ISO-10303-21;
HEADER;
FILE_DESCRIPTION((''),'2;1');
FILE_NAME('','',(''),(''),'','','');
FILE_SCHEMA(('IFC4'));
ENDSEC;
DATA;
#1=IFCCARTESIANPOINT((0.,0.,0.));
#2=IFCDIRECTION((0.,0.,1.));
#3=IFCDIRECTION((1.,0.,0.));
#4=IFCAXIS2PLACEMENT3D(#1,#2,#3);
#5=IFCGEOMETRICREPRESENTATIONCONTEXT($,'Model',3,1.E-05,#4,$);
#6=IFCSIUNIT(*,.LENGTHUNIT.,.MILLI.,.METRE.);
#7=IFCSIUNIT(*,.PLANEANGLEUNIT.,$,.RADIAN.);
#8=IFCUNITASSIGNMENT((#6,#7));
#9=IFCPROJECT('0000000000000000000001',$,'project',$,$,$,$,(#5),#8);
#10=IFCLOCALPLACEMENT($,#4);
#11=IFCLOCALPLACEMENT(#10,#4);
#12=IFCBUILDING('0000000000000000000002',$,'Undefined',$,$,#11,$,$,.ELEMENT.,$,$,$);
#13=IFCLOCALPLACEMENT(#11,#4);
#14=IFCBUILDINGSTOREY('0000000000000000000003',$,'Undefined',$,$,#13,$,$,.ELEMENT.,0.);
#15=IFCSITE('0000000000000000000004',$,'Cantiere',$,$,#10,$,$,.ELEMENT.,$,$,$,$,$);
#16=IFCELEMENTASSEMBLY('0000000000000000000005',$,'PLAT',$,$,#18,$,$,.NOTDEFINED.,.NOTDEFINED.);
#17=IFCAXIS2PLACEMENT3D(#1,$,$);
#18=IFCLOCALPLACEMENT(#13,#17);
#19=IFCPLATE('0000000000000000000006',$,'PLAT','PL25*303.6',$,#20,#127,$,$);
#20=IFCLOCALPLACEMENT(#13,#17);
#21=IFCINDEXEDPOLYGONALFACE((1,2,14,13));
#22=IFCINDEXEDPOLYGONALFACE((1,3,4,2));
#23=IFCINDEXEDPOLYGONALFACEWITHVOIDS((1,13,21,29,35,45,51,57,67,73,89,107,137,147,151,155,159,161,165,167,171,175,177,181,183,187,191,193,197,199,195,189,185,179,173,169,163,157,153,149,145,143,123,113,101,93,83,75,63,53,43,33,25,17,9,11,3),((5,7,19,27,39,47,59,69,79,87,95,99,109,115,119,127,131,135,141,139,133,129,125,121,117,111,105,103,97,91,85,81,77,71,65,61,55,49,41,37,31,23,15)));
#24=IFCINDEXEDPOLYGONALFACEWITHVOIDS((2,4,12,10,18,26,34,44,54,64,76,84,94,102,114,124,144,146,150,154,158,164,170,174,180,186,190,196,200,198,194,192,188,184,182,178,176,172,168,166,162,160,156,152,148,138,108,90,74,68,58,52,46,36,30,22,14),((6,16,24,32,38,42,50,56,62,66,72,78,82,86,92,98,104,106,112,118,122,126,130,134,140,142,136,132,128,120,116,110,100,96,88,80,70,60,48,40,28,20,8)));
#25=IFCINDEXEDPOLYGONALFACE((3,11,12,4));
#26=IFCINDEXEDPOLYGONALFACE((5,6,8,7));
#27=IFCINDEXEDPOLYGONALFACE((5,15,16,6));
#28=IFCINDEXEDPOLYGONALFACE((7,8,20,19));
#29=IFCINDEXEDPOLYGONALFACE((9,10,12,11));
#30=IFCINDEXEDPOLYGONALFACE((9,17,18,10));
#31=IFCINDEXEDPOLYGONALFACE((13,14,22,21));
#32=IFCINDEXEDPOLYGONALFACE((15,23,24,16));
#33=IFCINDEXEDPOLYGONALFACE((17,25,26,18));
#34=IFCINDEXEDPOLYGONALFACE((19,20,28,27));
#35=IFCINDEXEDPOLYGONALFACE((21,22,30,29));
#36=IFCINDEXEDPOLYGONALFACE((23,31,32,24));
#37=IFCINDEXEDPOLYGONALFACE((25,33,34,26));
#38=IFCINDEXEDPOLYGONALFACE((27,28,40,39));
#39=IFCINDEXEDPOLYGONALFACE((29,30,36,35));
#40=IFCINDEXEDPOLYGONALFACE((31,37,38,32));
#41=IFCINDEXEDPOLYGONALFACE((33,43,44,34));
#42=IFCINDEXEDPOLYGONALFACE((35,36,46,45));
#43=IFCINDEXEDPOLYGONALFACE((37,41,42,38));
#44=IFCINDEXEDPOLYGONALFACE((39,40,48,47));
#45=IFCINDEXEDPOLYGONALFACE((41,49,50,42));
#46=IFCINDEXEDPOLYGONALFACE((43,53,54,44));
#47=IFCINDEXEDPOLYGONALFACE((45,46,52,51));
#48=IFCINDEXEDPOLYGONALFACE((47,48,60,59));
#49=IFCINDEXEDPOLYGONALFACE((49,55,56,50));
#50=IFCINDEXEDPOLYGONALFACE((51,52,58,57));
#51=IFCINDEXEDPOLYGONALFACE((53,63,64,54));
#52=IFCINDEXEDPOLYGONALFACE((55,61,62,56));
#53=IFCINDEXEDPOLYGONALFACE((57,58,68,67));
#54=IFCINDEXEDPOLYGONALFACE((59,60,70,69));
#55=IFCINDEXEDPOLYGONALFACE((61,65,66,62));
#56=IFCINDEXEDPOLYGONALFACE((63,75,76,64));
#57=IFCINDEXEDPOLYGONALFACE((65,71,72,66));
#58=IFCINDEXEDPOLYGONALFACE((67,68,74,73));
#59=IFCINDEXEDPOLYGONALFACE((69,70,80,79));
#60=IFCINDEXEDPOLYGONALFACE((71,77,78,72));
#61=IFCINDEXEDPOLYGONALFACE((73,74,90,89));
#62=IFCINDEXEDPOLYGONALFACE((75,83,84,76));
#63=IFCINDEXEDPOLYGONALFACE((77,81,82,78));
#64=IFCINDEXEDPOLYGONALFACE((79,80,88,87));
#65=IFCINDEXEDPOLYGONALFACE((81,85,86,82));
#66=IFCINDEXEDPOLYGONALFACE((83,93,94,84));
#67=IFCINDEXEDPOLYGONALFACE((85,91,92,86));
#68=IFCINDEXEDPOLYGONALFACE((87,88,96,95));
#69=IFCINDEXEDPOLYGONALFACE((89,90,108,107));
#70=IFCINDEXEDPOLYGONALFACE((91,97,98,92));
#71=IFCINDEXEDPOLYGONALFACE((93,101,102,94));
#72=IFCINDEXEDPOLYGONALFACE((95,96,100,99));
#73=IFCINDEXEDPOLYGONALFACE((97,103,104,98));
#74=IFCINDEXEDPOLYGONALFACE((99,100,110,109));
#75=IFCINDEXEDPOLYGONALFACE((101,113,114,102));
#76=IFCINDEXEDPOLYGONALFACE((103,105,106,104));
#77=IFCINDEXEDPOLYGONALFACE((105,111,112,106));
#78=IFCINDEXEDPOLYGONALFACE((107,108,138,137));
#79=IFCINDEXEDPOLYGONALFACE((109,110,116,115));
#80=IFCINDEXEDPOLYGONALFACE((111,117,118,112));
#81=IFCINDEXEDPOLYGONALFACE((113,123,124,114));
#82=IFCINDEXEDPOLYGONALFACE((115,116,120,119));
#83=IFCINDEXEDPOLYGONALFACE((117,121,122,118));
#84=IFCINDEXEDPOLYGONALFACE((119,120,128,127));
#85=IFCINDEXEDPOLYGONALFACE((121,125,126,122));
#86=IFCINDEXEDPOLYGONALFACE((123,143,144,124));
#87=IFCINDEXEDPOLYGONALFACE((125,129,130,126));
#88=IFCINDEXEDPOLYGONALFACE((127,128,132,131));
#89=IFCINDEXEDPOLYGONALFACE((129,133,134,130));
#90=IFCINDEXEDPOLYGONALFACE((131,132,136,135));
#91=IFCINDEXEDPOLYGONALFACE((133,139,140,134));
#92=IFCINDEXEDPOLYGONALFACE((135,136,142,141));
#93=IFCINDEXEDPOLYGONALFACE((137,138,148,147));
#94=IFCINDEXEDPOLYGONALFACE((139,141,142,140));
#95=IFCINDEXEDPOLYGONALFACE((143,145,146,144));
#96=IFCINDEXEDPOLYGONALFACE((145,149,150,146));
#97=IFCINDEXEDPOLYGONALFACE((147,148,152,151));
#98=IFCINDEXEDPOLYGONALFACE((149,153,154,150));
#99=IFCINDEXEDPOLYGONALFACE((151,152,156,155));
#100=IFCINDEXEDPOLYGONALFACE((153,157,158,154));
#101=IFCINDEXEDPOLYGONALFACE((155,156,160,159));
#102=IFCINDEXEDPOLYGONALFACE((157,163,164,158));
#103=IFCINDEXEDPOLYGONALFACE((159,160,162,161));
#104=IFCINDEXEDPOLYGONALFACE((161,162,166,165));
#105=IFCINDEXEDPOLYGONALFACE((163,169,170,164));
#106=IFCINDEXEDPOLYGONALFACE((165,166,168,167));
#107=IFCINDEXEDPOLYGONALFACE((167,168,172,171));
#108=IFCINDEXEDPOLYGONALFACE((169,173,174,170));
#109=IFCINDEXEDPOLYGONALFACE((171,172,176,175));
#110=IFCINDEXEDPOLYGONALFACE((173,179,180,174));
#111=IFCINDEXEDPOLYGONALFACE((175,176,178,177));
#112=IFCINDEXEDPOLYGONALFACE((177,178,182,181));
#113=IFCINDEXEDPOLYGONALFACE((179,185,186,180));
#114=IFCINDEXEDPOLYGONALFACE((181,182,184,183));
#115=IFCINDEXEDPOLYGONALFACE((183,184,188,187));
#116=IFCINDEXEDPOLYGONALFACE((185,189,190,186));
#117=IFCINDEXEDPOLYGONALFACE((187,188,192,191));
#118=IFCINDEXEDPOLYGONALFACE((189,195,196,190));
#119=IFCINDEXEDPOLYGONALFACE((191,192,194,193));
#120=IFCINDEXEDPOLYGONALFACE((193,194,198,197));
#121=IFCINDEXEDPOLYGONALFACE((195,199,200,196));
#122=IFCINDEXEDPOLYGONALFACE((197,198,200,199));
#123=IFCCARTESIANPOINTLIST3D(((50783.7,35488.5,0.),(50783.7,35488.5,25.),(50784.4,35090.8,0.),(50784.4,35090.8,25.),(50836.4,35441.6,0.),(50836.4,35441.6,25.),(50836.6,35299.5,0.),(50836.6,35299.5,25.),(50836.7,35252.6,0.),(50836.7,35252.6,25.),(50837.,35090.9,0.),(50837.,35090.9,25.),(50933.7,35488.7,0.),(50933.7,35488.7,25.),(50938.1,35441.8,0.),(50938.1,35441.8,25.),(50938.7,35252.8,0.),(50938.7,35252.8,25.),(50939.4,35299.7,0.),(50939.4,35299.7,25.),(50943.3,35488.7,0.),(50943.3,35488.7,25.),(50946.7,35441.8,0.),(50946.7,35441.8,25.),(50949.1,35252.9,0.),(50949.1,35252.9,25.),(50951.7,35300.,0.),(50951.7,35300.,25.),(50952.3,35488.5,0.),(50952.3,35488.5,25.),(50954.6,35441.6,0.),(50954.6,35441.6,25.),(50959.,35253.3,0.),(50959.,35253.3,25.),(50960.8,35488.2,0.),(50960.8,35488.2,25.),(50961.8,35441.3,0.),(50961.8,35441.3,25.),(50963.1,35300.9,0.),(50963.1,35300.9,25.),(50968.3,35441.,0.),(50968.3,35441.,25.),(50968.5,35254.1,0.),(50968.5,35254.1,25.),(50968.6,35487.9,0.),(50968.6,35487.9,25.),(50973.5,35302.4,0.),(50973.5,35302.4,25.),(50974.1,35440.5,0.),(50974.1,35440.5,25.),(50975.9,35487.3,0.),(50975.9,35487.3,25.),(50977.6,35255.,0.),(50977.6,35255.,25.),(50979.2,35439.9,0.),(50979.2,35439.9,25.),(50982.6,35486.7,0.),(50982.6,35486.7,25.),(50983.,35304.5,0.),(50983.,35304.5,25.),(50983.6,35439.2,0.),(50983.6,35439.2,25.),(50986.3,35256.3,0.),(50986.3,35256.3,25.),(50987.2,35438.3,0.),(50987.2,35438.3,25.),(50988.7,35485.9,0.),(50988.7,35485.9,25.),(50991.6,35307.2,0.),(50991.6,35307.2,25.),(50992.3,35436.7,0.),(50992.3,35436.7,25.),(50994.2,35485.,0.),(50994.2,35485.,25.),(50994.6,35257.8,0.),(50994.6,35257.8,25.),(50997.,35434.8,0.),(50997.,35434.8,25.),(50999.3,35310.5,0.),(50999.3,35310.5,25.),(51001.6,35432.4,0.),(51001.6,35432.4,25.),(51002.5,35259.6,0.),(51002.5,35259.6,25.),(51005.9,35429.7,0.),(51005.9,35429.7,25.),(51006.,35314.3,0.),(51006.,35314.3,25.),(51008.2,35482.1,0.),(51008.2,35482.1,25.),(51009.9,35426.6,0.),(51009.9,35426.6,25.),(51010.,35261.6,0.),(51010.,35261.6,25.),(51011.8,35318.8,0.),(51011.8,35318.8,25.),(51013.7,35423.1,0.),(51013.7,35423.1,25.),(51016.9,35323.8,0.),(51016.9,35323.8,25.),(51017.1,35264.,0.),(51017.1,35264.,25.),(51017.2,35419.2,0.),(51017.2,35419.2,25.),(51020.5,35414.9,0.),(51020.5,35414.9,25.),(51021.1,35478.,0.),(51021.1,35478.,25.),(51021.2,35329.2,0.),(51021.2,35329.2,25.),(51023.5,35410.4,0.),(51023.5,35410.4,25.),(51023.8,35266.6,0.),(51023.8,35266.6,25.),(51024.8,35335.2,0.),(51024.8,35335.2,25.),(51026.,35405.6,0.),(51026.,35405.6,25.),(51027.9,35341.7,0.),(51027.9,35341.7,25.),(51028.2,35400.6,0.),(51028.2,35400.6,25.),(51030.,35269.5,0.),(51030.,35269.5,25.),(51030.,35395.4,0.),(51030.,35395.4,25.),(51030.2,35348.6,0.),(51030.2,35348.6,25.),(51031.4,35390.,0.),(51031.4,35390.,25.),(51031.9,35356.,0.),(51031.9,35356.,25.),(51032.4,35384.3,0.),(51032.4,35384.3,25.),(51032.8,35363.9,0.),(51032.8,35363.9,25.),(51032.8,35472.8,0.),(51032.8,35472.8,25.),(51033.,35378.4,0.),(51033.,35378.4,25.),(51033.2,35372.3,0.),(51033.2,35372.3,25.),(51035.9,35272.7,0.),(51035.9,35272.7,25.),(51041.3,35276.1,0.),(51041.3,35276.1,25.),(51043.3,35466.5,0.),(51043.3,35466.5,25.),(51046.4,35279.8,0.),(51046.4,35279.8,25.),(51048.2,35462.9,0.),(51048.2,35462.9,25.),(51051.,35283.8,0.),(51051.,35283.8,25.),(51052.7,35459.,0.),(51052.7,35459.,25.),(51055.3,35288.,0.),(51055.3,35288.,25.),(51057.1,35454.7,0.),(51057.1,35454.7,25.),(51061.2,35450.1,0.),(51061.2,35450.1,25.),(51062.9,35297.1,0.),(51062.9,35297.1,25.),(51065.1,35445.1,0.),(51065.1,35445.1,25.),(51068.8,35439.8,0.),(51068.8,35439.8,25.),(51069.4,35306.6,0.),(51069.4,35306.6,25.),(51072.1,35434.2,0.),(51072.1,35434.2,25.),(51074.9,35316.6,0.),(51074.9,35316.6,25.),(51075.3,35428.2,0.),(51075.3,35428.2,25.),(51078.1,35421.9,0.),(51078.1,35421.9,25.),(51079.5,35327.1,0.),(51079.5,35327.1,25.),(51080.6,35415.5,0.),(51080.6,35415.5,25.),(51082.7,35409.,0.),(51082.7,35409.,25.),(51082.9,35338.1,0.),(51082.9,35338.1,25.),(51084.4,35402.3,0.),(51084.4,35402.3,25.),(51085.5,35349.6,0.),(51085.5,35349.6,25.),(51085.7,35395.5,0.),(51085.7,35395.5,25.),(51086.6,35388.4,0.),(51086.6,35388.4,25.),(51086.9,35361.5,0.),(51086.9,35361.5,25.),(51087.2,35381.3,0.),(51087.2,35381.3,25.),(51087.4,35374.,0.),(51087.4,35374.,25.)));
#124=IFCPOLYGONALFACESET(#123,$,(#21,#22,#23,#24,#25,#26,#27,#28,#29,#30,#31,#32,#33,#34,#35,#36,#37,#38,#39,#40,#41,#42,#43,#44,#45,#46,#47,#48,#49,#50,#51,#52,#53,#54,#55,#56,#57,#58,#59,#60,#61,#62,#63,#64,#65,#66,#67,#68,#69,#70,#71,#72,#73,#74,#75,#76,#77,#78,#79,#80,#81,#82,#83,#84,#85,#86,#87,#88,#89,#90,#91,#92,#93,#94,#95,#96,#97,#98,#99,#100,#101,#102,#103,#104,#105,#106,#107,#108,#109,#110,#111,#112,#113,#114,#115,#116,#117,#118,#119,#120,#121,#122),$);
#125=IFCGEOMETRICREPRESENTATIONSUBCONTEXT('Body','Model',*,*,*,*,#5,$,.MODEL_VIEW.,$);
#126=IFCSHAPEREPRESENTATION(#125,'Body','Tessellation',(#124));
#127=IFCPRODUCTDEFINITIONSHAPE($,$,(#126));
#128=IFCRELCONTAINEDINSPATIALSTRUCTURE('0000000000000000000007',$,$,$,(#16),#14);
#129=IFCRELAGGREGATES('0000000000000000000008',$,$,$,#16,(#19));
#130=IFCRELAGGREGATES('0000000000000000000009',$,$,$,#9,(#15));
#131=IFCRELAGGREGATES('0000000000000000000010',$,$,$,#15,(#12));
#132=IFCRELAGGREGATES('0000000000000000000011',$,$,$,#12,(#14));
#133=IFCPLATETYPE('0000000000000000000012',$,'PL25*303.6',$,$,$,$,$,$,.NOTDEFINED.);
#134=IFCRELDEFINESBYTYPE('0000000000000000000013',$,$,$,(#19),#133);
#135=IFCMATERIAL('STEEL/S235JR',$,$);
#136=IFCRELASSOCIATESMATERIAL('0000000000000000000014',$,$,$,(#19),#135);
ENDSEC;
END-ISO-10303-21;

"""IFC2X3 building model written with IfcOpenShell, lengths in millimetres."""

from ifc_helpers import new_model, si_unit, frame, origin_with_axes, place, context, subcontext, project, spatial, polyline, outline, extrude, boolean, material, type_object, element, aggregate, save


model = new_model("IFC2X3")

# Units and contexts
model_context = context("Model", 3, precision=1e-05, world=origin_with_axes())
body_context = subcontext(model_context, "Body", "Model", "MODEL_VIEW")
ifc_project = project(units=[si_unit("LENGTHUNIT", "METRE", prefix="MILLI"), si_unit("PLANEANGLEUNIT", "RADIAN")], contexts=[model_context])

# Site, building, storey
site_placement = place(None, origin_with_axes())
site = spatial("IfcSite", under=ifc_project, at=site_placement, Name="Cantiere", CompositionType="ELEMENT")
building_placement = place(site_placement, origin_with_axes())
building = spatial("IfcBuilding", under=site, at=building_placement, Name="Undefined", CompositionType="ELEMENT")
storey_placement = place(building_placement, origin_with_axes())
storey = spatial("IfcBuildingStorey", under=building, at=storey_placement, Name="Undefined", CompositionType="ELEMENT", Elevation=0.0)

# Shared definitions
ifc_material_1 = material(Name="STEEL/S235JR")

# Element assembly, plate
assembly_1_placement = place(storey_placement, origin_with_axes())
assembly_1 = element("IfcElementAssembly", 1, at=assembly_1_placement, inside=storey, Name="PLAT", AssemblyPlace="NOTDEFINED", PredefinedType="NOTDEFINED")
plate_type_1 = type_object("IfcPlateType", Name="PL25*303.6", PredefinedType="NOTDEFINED")
plate_1_placement = place(assembly_1_placement, frame((50784.4, 35090.8, 12.5), z_axis=(0.0, 0.000001, -1.0), x_axis=(-0.001693, 0.999999, 0.0)))
plate_1 = element("IfcPlate", 2, at=plate_1_placement, type_object=plate_type_1, material=ifc_material_1, Name="PLAT", Description="PL25*303.6", context=body_context, shape_type="CSG", body=[
    boolean("DIFFERENCE", extrude(outline(polyline([(0.0, 0.0), (397.7, 0.0), (397.7, 150.0), (397.7, 159.6), (397.5, 168.7), (397.2, 177.1), (396.8, 185.0), (396.2, 192.2), (395.6, 198.9), (394.8, 205.0), (393.9, 210.5), (390.9, 224.6), (386.8, 237.5), (381.6, 249.1), (375.3, 259.6), (371.7, 264.5), (367.8, 269.0), (363.5, 273.4), (358.9, 277.5), (353.9, 281.4), (348.6, 285.0), (342.9, 288.4), (336.9, 291.5), (330.7, 294.4), (324.3, 296.8), (317.7, 298.9), (311.0, 300.6), (304.2, 301.9), (297.1, 302.8), (290.0, 303.4), (282.7, 303.6), (270.2, 303.1), (258.3, 301.6), (246.8, 299.0), (235.8, 295.5), (225.3, 291.0), (215.3, 285.4), (205.8, 278.9), (196.8, 271.3), (192.5, 267.0), (188.5, 262.4), (184.8, 257.3), (181.5, 251.9), (178.3, 246.0), (175.4, 239.8), (172.8, 233.1), (170.4, 226.0), (168.4, 218.5), (166.6, 210.6), (165.1, 202.3), (163.9, 193.6), (162.9, 184.5), (162.2, 174.9), (161.8, 165.0), (161.7, 154.7), (161.7, 52.7), (0.0, 52.7), (0.0, 0.0)])), frame((0.0, 0.0, -12.5), z_axis=(0.0, 0.0, 1.0), x_axis=(1.0, 0.0, 0.0)), (0.0, 0.0, 1.0), 25.0), extrude(outline(polyline([(0.0, 0.0), (102.8, 0.0), (115.1, 0.3), (126.5, 1.2), (136.9, 2.7), (146.4, 4.8), (155.0, 7.5), (162.7, 10.7), (169.4, 14.6), (175.2, 19.0), (180.3, 24.0), (184.6, 29.5), (188.3, 35.4), (191.3, 41.9), (193.7, 48.8), (195.3, 56.2), (196.3, 64.1), (196.7, 72.5), (196.5, 78.6), (195.9, 84.5), (194.9, 90.2), (193.5, 95.6), (191.8, 100.8), (189.5, 105.8), (187.0, 110.6), (184.0, 115.2), (180.8, 119.4), (177.3, 123.3), (173.5, 126.8), (169.5, 129.9), (165.2, 132.7), (160.6, 135.0), (155.9, 137.0), (150.8, 138.6), (147.2, 139.5), (142.8, 140.2), (137.7, 140.8), (131.9, 141.3), (125.4, 141.7), (118.2, 142.0), (110.3, 142.1), (101.7, 142.2), (0.0, 142.2), (0.0, 0.0)])), frame((208.6, 52.7, 12.5), z_axis=(0.0, 0.000001, -1.0), x_axis=(0.0, 1.0, 0.0)), (0.0, 0.0, 1.0), 25.0)),
])
aggregate(assembly_1, [plate_1])

save(model, "model.ifc")
